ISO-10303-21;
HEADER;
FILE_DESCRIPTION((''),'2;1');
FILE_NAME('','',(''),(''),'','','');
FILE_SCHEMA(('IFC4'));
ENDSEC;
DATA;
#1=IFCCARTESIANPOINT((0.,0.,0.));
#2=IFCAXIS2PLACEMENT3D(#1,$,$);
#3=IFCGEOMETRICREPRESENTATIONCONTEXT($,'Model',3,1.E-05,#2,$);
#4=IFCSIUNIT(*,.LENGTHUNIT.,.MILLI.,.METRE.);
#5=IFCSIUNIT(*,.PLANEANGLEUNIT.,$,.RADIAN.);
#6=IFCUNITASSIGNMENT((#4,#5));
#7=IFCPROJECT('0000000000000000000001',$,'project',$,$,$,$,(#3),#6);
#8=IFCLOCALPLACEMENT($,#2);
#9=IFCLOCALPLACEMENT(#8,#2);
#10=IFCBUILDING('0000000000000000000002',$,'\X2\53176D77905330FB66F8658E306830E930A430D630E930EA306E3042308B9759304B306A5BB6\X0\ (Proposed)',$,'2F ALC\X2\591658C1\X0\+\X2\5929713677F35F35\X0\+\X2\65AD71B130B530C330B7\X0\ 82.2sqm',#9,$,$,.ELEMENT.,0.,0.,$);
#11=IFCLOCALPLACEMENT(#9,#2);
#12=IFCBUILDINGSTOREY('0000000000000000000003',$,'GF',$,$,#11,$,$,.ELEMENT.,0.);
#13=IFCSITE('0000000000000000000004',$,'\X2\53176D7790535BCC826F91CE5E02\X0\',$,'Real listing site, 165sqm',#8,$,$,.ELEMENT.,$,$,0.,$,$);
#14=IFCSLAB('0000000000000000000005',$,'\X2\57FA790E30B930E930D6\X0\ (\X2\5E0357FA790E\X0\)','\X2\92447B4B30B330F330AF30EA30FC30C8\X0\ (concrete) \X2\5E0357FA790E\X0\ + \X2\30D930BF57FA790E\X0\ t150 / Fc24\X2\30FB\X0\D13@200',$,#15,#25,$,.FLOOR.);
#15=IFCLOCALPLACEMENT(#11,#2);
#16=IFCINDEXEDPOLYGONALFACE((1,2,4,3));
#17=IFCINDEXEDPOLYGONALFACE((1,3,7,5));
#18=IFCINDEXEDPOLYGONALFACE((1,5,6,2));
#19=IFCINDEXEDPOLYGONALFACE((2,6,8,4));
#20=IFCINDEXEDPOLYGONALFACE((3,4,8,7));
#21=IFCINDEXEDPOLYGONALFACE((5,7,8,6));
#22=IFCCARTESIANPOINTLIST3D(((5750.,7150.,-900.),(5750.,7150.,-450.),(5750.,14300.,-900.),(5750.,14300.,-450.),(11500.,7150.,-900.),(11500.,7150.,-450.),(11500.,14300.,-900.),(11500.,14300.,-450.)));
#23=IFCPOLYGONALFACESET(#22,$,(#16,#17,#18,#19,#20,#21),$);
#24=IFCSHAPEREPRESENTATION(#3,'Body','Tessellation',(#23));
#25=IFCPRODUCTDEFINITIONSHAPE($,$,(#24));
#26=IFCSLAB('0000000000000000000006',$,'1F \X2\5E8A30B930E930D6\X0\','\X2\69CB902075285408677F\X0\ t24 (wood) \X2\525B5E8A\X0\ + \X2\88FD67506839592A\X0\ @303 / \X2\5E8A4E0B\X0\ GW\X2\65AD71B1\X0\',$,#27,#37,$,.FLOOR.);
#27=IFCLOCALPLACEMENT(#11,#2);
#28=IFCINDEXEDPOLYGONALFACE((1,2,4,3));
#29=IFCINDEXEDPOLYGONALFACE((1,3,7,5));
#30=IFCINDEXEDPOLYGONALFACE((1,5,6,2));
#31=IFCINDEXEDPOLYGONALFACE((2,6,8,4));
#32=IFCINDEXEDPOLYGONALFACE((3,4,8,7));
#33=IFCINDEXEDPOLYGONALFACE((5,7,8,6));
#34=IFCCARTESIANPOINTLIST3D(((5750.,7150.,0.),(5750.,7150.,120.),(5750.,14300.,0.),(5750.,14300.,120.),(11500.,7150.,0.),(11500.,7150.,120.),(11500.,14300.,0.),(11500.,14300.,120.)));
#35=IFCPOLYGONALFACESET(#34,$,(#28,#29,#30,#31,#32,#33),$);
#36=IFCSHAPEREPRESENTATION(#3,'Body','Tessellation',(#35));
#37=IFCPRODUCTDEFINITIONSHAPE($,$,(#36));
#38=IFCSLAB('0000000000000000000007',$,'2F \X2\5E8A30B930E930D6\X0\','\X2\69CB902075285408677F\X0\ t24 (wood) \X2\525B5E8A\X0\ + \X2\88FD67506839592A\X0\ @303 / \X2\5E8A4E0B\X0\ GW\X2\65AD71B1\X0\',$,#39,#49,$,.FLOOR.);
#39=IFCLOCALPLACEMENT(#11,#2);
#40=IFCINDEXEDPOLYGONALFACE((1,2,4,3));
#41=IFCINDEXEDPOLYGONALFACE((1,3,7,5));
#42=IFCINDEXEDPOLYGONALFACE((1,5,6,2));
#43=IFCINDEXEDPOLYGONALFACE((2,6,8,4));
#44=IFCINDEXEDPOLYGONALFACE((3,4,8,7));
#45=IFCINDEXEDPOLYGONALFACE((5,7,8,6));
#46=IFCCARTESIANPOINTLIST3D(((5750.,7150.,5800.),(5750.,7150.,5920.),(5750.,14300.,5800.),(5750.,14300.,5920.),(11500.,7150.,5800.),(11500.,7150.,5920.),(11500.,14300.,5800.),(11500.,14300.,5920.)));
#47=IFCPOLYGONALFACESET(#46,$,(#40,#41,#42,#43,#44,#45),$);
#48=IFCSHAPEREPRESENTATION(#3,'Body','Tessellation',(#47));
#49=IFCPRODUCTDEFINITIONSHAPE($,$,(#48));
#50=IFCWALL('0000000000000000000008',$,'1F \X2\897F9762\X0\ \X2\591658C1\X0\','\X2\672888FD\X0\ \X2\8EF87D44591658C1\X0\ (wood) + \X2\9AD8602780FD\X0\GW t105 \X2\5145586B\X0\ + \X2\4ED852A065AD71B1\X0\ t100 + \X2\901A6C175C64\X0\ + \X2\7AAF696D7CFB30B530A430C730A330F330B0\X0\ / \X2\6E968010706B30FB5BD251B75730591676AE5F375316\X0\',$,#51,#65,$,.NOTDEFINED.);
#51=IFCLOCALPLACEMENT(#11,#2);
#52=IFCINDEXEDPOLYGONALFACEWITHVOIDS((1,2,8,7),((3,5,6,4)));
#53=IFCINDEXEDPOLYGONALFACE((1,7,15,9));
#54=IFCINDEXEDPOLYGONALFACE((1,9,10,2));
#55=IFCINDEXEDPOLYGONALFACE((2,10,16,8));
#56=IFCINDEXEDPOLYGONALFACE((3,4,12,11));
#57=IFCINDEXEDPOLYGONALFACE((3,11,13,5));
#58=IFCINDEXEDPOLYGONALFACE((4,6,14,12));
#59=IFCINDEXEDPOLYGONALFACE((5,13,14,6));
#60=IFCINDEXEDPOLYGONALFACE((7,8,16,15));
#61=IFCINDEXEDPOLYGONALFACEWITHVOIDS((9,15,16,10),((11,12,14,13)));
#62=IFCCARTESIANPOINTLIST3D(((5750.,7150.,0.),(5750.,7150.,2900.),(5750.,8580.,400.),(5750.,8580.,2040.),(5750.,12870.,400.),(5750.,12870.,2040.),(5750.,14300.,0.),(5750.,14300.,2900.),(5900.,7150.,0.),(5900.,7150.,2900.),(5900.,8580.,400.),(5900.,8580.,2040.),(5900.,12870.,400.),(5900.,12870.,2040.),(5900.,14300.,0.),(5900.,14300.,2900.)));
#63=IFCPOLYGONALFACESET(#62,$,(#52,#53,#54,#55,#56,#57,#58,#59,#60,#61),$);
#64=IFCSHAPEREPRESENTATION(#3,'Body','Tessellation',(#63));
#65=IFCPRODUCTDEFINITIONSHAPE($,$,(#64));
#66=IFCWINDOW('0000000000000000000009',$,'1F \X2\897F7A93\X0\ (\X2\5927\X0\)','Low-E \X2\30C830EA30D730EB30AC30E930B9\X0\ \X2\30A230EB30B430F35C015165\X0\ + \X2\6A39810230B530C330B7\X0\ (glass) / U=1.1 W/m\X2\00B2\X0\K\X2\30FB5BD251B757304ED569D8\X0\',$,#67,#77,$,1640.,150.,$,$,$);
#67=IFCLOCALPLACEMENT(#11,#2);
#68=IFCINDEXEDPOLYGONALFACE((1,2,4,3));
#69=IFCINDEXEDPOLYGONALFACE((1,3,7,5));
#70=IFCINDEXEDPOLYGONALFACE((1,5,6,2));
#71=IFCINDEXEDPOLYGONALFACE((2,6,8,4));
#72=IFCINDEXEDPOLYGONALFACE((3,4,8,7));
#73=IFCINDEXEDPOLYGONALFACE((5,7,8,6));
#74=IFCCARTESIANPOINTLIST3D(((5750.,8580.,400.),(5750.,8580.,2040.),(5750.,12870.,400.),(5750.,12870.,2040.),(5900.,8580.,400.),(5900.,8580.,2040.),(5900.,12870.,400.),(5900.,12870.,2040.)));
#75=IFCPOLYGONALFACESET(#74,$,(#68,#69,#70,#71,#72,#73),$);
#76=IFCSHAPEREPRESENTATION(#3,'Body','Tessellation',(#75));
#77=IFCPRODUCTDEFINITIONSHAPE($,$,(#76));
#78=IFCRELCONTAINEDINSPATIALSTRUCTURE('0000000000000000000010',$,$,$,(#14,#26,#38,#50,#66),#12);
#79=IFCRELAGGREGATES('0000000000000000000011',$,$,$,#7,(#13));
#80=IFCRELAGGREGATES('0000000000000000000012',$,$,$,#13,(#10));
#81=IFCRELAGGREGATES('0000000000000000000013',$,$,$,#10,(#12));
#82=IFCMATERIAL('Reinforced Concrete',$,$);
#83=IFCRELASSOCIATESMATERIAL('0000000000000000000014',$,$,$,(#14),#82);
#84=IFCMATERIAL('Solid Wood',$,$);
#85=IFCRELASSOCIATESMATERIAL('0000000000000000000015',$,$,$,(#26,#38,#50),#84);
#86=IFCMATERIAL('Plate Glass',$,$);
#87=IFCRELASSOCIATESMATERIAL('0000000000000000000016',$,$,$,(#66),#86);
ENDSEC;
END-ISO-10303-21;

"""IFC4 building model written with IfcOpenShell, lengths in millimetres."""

from ifc_helpers import new_model, si_unit, frame, frame_2d, origin, place, context, project, spatial, rectangle, extrude, material, element, fill, save


model = new_model("IFC4")

# Units and contexts
model_context = context("Model", 3, precision=1e-05, world=origin())
ifc_project = project(units=[si_unit("LENGTHUNIT", "METRE", prefix="MILLI"), si_unit("PLANEANGLEUNIT", "RADIAN")], contexts=[model_context])

# Site, building, storey
site_placement = place(None, origin())
site = spatial("IfcSite", under=ifc_project, at=site_placement, Name="北海道富良野市", ObjectType="Real listing site, 165sqm", CompositionType="ELEMENT", RefElevation=0.0)
building_placement = place(site_placement, origin())
building = spatial("IfcBuilding", under=site, at=building_placement, Name="北海道・書斎とライブラリのある静かな家 (Proposed)", ObjectType="2F ALC外壁+天然石張+断熱サッシ 82.2sqm", CompositionType="ELEMENT", ElevationOfRefHeight=0.0, ElevationOfTerrain=0.0)
storey_placement = place(building_placement, origin())
storey = spatial("IfcBuildingStorey", under=building, at=storey_placement, Name="GF", CompositionType="ELEMENT", Elevation=0.0)

# Shared definitions
ifc_material_1 = material(Name="Solid Wood")

# Slabs
ifc_material_2 = material(Name="Reinforced Concrete")
slab_1_placement = place(storey_placement, frame((2875.0, 3575.0, -450.0)))
element("IfcSlab", 1, at=slab_1_placement, inside=storey, material=ifc_material_2, Name="基礎スラブ (布基礎)", Description="鉄筋コンクリート (concrete) 布基礎 + ベタ基礎 t150 / Fc24・D13@200", PredefinedType="FLOOR", context=model_context, shape_type="SweptSolid", body=[
    extrude(rectangle(XDim=5750.0, YDim=7150.0, at=frame_2d((2875.0, 3575.0))), frame((2875.0, 3575.0, -450.0)), (0.0, 0.0, 1.0), 450.0),
])
slab_2_placement = place(storey_placement, frame((2875.0, 3575.0, 0.0)))
element("IfcSlab", 2, at=slab_2_placement, inside=storey, material=ifc_material_1, Name="1F 床スラブ", Description="構造用合板 t24 (wood) 剛床 + 製材根太 @303 / 床下 GW断熱", PredefinedType="FLOOR", context=model_context, shape_type="SweptSolid", body=[
    extrude(rectangle(XDim=5750.0, YDim=7150.0, at=frame_2d((2875.0, 3575.0))), frame((2875.0, 3575.0, 0.0)), (0.0, 0.0, 1.0), 120.0),
])
slab_3_placement = place(storey_placement, frame((2875.0, 3575.0, 2900.0)))
element("IfcSlab", 3, at=slab_3_placement, inside=storey, material=ifc_material_1, Name="2F 床スラブ", Description="構造用合板 t24 (wood) 剛床 + 製材根太 @303 / 床下 GW断熱", PredefinedType="FLOOR", context=model_context, shape_type="SweptSolid", body=[
    extrude(rectangle(XDim=5750.0, YDim=7150.0, at=frame_2d((2875.0, 3575.0))), frame((2875.0, 3575.0, 2900.0)), (0.0, 0.0, 1.0), 120.0),
])

# Shared definitions
ifc_material_3 = material(Name="Plate Glass")

# Wall, opening, window
wall_1_placement = place(storey_placement, frame((2875.0, 3575.0, 0.0)))
wall_1 = element("IfcWall", 4, at=wall_1_placement, inside=storey, material=ifc_material_1, Name="1F 西面 外壁", Description="木製 軸組外壁 (wood) + 高性能GW t105 充填 + 付加断熱 t100 + 通気層 + 窯業系サイディング / 準耐火・寒冷地外皮強化", PredefinedType="NOTDEFINED", context=model_context, shape_type="SweptSolid", body=[
    extrude(rectangle(XDim=150.0, YDim=7150.0, at=frame_2d((75.0, 3575.0))), frame((2875.0, 3575.0, 0.0)), (0.0, 0.0, 1.0), 2900.0),
])
opening_1_placement = place(storey_placement, frame((2875.0, 4290.0, 200.0)))
opening_1 = element("IfcOpeningElement", 5, at=opening_1_placement, cuts=wall_1, PredefinedType="NOTDEFINED", context=model_context, shape_type="SweptSolid", body=[
    extrude(rectangle(XDim=150.0, YDim=4290.0, at=frame_2d((75.0, 2145.0))), frame((2875.0, 4290.0, 200.0)), (0.0, 0.0, 1.0), 1640.0),
])
window_1_placement = place(storey_placement, frame((2875.0, 4290.0, 200.0)))
window_1 = element("IfcWindow", 6, at=window_1_placement, inside=storey, material=ifc_material_3, Name="1F 西窓 (大)", Description="Low-E トリプルガラス アルゴン封入 + 樹脂サッシ (glass) / U=1.1 W/m²K・寒冷地仕様", OverallHeight=1640.0, OverallWidth=150.0, context=model_context, shape_type="SweptSolid", body=[
    extrude(rectangle(XDim=150.0, YDim=4290.0, at=frame_2d((75.0, 2145.0))), frame((2875.0, 4290.0, 200.0)), (0.0, 0.0, 1.0), 1640.0),
])
fill(opening_1, window_1)

save(model, "model.ifc")
